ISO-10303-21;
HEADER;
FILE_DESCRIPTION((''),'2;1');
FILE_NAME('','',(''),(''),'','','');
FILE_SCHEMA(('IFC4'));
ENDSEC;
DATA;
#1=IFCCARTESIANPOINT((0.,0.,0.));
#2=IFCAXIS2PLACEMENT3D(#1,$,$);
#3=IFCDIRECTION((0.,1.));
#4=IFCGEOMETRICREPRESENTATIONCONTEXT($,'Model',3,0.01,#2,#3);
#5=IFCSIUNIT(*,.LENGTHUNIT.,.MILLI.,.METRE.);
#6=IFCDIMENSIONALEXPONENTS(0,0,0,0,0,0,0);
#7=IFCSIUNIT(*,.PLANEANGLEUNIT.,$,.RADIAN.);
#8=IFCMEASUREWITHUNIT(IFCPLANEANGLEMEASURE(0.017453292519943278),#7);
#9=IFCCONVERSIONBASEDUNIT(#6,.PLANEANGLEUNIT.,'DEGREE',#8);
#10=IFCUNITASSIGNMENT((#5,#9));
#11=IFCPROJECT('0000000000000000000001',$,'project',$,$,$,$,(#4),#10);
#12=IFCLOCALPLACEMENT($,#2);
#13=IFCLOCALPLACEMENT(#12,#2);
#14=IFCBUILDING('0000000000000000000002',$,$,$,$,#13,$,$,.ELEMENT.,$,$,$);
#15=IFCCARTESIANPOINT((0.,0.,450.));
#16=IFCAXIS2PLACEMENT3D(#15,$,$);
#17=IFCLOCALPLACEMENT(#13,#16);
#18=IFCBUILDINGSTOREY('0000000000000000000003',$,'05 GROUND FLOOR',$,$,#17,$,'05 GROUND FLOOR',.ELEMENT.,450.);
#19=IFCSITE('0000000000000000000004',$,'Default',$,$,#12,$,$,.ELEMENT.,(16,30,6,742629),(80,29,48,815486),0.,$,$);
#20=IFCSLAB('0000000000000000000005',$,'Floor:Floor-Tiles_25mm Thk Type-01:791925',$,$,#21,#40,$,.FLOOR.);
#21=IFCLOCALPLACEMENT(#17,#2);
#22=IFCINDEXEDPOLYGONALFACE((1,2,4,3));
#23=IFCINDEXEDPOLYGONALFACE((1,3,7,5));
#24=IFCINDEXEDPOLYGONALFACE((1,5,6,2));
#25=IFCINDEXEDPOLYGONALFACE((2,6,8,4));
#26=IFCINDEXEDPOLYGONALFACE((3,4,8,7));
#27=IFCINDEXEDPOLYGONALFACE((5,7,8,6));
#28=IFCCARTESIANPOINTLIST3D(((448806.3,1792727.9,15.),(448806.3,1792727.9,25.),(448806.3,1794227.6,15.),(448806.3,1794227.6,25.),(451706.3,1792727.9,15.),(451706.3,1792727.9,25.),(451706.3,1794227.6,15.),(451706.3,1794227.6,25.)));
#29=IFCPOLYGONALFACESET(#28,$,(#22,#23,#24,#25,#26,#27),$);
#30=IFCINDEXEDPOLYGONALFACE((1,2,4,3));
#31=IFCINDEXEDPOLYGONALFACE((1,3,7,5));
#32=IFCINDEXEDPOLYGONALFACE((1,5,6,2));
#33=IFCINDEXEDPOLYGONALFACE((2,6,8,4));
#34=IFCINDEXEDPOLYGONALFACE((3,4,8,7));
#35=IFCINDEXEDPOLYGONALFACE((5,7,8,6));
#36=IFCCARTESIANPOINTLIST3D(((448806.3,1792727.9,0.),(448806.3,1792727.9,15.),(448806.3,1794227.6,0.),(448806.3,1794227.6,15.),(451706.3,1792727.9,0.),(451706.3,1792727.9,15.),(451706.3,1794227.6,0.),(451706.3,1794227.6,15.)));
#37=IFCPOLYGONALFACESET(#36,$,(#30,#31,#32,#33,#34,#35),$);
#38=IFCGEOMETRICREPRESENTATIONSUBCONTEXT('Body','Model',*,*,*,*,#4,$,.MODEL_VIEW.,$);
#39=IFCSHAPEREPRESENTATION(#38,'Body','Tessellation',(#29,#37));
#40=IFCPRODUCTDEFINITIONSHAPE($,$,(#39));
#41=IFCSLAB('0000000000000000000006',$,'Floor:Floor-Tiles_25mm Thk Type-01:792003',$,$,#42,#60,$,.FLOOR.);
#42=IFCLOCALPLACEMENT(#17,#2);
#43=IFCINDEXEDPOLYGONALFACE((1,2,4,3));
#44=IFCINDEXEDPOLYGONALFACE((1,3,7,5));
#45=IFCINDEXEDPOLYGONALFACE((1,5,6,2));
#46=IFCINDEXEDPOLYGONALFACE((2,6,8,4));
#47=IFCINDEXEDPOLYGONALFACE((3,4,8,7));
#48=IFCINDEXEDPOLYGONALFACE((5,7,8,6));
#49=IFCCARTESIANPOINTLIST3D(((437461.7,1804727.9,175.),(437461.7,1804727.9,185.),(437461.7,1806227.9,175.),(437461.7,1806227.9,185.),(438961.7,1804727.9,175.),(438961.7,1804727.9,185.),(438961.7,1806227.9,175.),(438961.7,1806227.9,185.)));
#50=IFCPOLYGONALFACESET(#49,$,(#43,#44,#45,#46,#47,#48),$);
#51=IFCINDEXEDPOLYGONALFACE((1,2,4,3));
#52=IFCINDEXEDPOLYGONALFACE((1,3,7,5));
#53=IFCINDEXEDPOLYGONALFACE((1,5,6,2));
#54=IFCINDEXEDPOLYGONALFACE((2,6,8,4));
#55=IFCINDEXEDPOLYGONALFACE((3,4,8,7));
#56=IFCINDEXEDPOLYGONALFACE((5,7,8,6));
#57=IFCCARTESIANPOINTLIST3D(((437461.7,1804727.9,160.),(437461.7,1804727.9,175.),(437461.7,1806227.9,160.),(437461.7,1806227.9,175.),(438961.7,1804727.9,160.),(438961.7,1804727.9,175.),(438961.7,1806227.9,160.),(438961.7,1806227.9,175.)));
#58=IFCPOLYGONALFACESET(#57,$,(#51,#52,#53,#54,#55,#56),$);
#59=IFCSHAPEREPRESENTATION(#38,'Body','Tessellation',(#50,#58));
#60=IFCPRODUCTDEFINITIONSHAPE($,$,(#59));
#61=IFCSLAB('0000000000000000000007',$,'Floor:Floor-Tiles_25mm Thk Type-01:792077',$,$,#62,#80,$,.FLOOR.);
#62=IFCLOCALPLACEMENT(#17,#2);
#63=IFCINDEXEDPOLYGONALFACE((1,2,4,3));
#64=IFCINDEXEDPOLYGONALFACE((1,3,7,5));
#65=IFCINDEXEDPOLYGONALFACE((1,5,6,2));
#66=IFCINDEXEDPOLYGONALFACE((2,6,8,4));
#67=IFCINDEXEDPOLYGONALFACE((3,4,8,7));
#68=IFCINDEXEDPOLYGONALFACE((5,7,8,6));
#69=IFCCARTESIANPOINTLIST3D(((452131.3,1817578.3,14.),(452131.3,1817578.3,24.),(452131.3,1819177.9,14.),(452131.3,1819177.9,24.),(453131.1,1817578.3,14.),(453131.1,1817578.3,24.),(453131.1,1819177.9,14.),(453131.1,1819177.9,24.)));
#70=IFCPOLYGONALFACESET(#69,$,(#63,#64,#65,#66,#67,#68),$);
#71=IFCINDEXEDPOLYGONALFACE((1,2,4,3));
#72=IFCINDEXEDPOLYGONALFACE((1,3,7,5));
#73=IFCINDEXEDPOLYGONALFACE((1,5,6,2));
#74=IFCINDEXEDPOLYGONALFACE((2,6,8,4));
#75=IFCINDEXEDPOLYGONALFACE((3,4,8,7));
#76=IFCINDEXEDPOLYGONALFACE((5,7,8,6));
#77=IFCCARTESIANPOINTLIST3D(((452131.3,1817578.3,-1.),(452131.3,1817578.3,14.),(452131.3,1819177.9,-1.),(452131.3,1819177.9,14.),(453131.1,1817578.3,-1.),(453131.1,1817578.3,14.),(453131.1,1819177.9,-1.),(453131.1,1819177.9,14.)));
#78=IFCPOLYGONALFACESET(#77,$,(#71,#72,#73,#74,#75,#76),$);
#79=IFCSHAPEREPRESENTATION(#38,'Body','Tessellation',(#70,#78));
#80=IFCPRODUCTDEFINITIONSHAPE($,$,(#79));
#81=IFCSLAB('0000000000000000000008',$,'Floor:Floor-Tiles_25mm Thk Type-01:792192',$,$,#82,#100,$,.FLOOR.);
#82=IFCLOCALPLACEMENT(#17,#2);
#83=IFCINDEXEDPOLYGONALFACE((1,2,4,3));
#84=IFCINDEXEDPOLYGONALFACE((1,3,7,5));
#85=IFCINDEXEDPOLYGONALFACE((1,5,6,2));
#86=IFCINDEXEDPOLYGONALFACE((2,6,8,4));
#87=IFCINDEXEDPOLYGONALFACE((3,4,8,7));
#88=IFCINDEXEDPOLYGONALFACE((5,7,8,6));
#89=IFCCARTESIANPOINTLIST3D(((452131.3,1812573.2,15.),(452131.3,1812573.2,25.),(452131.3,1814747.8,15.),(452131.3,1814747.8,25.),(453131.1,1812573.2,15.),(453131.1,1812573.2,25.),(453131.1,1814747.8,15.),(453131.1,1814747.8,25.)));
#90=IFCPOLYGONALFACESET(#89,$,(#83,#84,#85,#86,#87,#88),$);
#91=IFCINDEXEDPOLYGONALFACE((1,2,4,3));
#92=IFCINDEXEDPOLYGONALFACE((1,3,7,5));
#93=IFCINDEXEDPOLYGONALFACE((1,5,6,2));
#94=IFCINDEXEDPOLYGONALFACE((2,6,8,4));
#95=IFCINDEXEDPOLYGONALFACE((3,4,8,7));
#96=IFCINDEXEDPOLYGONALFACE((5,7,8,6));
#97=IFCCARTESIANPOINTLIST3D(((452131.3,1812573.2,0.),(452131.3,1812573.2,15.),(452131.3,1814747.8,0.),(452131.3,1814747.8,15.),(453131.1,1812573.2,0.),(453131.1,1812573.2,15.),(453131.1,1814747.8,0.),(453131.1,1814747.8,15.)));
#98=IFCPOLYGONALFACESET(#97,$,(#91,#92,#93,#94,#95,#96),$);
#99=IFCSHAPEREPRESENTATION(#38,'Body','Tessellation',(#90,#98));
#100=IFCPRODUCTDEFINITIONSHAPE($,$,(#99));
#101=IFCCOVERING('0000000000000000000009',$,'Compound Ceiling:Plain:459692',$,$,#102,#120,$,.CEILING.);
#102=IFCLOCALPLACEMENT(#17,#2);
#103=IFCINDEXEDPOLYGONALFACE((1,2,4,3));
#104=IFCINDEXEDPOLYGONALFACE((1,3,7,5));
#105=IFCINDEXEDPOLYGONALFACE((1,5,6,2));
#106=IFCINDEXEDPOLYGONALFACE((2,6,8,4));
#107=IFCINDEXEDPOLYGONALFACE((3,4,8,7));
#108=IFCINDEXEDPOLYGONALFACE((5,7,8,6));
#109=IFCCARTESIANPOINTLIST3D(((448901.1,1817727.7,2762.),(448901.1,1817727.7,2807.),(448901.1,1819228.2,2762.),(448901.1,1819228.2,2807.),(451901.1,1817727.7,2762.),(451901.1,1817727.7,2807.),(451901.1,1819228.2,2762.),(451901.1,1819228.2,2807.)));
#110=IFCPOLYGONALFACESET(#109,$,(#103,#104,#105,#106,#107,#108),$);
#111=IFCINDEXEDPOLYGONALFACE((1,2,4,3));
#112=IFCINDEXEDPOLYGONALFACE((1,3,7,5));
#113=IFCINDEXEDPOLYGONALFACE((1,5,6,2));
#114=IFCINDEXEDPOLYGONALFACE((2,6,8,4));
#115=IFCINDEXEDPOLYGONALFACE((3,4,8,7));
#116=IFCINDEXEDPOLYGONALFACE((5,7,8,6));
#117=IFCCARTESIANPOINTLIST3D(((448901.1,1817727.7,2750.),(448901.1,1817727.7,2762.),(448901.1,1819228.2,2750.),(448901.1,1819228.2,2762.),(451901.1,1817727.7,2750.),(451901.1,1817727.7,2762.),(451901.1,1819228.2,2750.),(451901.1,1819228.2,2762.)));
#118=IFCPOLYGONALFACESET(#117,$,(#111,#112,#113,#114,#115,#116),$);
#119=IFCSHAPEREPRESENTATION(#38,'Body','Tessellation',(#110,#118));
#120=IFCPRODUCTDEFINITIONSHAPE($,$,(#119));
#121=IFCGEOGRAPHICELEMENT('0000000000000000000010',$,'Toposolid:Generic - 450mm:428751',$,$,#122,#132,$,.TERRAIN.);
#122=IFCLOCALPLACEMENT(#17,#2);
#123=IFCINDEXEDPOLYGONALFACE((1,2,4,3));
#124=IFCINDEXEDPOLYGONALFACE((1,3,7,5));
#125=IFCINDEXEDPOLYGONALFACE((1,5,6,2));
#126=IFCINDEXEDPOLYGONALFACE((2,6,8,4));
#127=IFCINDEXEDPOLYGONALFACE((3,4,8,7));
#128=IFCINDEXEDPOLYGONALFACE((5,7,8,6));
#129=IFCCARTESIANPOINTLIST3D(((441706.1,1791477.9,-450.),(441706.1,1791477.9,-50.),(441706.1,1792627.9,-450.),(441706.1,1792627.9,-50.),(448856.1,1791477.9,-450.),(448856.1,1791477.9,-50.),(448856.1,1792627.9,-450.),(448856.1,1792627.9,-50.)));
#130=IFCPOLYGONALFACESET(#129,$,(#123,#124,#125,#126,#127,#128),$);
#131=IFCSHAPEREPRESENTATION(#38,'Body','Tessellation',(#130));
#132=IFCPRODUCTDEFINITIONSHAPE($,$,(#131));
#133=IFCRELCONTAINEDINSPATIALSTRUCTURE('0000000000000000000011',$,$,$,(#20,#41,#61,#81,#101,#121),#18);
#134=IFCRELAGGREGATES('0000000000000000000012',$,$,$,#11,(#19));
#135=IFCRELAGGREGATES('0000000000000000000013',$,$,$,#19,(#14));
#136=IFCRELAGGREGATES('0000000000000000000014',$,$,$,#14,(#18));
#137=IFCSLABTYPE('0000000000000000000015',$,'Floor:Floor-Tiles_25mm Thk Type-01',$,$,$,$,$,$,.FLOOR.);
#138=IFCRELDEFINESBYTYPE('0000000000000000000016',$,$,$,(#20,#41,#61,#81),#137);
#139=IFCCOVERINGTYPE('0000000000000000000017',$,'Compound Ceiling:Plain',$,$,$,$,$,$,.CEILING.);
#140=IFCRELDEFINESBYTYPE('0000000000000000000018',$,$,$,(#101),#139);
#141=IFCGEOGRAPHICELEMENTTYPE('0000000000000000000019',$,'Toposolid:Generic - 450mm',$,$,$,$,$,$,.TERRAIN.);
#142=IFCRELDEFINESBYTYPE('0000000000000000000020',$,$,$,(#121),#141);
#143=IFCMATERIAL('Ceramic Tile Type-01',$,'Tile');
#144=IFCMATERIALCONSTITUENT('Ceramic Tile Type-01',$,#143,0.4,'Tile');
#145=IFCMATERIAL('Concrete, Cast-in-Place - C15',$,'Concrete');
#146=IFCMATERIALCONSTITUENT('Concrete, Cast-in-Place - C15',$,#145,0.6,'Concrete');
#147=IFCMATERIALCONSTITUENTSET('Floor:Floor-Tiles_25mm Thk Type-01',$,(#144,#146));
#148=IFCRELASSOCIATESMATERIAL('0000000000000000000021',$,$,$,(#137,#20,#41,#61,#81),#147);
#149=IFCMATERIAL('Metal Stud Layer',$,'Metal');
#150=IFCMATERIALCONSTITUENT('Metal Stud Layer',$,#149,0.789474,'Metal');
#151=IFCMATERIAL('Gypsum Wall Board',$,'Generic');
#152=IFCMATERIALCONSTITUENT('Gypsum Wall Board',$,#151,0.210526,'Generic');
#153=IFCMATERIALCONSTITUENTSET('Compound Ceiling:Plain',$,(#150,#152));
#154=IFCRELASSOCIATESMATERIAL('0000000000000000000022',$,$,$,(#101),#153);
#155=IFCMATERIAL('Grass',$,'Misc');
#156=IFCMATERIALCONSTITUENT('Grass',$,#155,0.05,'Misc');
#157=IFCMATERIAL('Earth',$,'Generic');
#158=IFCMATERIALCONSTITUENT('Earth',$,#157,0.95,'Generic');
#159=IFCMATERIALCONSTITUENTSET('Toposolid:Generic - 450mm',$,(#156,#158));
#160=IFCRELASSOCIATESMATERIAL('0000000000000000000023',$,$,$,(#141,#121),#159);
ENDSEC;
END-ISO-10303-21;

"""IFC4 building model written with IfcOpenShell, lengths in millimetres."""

from ifc_helpers import new_model, entity, si_unit, converted_unit, direction, frame, origin, place, context, subcontext, project, spatial, indexed_curve, outline, extrude, material, constituent, constituent_set, type_object, element, save


model = new_model("IFC4")

# Units and contexts
model_context = context("Model", 3, precision=0.01, world=origin(), true_north=direction((0.0, 1.0)))
body_context = subcontext(model_context, "Body", "Model", "MODEL_VIEW")
ifc_project = project(units=[si_unit("LENGTHUNIT", "METRE", prefix="MILLI"), converted_unit("PLANEANGLEUNIT", "DEGREE", entity("IfcPlaneAngleMeasure", 0.017453292519943278), si_unit("PLANEANGLEUNIT", "RADIAN"), dimensions=[0, 0, 0, 0, 0, 0, 0])], contexts=[model_context])

# Site, building, storey
site_placement = place(None, origin())
site = spatial("IfcSite", under=ifc_project, at=site_placement, Name="Default", CompositionType="ELEMENT", RefLatitude=(16, 30, 6, 742629), RefLongitude=(80, 29, 48, 815486), RefElevation=0.0)
building_placement = place(site_placement, origin())
building = spatial("IfcBuilding", under=site, at=building_placement, CompositionType="ELEMENT")
storey_placement = place(building_placement, frame((0.0, 0.0, 450.0)))
storey = spatial("IfcBuildingStorey", under=building, at=storey_placement, Name="05 GROUND FLOOR", LongName="05 GROUND FLOOR", CompositionType="ELEMENT", Elevation=450.0)

# Slabs
ifc_material_1 = material(Name="Concrete, Cast-in-Place - C15", Category="Concrete")
ifc_material_2 = material(Name="Ceramic Tile Type-01", Category="Tile")
ifc_constituent_1 = constituent(ifc_material_2, Name="Ceramic Tile Type-01", Category="Tile", fraction=0.4)
ifc_constituent_2 = constituent(ifc_material_1, Name="Concrete, Cast-in-Place - C15", Category="Concrete", fraction=0.6)
ifc_constituent_set_1 = constituent_set(constituents=[ifc_constituent_1, ifc_constituent_2], Name="Floor:Floor-Tiles_25mm Thk Type-01")
slab_type_1 = type_object("IfcSlabType", Name="Floor:Floor-Tiles_25mm Thk Type-01", PredefinedType="FLOOR", material=ifc_constituent_set_1)
slab_1_placement = place(storey_placement, origin())
element("IfcSlab", 1, at=slab_1_placement, inside=storey, type_object=slab_type_1, material=ifc_constituent_set_1, Name="Floor:Floor-Tiles_25mm Thk Type-01:791925", PredefinedType="FLOOR", context=body_context, shape_type="SweptSolid", body=[
    extrude(outline(indexed_curve([(-1450.0, -749.9), (1450.0, -749.9), (1450.0, 749.9), (-1450.0, 749.9), (-1450.0, -749.9)], self_intersect=False)), frame((450256.3, 1793477.8, 15.0), z_axis=(0.0, 0.0, 1.0), x_axis=(-1.0, 0.0, 0.0)), (0.0, 0.0, 1.0), 10.0),
    extrude(outline(indexed_curve([(-1450.0, -749.9), (1450.0, -749.9), (1450.0, 749.9), (-1450.0, 749.9), (-1450.0, -749.9)], self_intersect=False)), frame((450256.3, 1793477.8, 0.0), z_axis=(0.0, 0.0, 1.0), x_axis=(-1.0, 0.0, 0.0)), (0.0, 0.0, 1.0), 15.0),
])
slab_2_placement = place(storey_placement, origin())
element("IfcSlab", 2, at=slab_2_placement, inside=storey, type_object=slab_type_1, material=ifc_constituent_set_1, Name="Floor:Floor-Tiles_25mm Thk Type-01:792003", PredefinedType="FLOOR", context=body_context, shape_type="SweptSolid", body=[
    extrude(outline(indexed_curve([(-750.0, -750.0), (750.0, -750.0), (750.0, 750.0), (-750.0, 750.0), (-750.0, -750.0)], self_intersect=False)), frame((438211.7, 1805477.9, 175.0), z_axis=(0.0, 0.0, 1.0), x_axis=(0.0, 1.0, 0.0)), (0.0, 0.0, 1.0), 10.0),
    extrude(outline(indexed_curve([(-750.0, -750.0), (750.0, -750.0), (750.0, 750.0), (-750.0, 750.0), (-750.0, -750.0)], self_intersect=False)), frame((438211.7, 1805477.9, 160.0), z_axis=(0.0, 0.0, 1.0), x_axis=(0.0, 1.0, 0.0)), (0.0, 0.0, 1.0), 15.0),
])
slab_3_placement = place(storey_placement, origin())
element("IfcSlab", 3, at=slab_3_placement, inside=storey, type_object=slab_type_1, material=ifc_constituent_set_1, Name="Floor:Floor-Tiles_25mm Thk Type-01:792077", PredefinedType="FLOOR", context=body_context, shape_type="SweptSolid", body=[
    extrude(outline(indexed_curve([(-799.8, -499.9), (799.8, -499.9), (799.8, 499.9), (-799.8, 499.9), (-799.8, -499.9)], self_intersect=False)), frame((452631.2, 1818378.1, 14.0), z_axis=(0.0, 0.0, 1.0), x_axis=(0.0, -1.0, 0.0)), (0.0, 0.0, 1.0), 10.0),
    extrude(outline(indexed_curve([(-799.8, -499.9), (799.8, -499.9), (799.8, 499.9), (-799.8, 499.9), (-799.8, -499.9)], self_intersect=False)), frame((452631.2, 1818378.1, -1.0), z_axis=(0.0, 0.0, 1.0), x_axis=(0.0, -1.0, 0.0)), (0.0, 0.0, 1.0), 15.0),
])
slab_4_placement = place(storey_placement, origin())
element("IfcSlab", 4, at=slab_4_placement, inside=storey, type_object=slab_type_1, material=ifc_constituent_set_1, Name="Floor:Floor-Tiles_25mm Thk Type-01:792192", PredefinedType="FLOOR", context=body_context, shape_type="SweptSolid", body=[
    extrude(outline(indexed_curve([(-499.9, -1087.3), (499.9, -1087.3), (499.9, 1087.3), (-499.9, 1087.3), (-499.9, -1087.3)], self_intersect=False)), frame((452631.2, 1813660.5, 15.0), z_axis=(0.0, 0.0, 1.0), x_axis=(-1.0, 0.0, 0.0)), (0.0, 0.0, 1.0), 10.0),
    extrude(outline(indexed_curve([(-499.9, -1087.3), (499.9, -1087.3), (499.9, 1087.3), (-499.9, 1087.3), (-499.9, -1087.3)], self_intersect=False)), frame((452631.2, 1813660.5, 0.0), z_axis=(0.0, 0.0, 1.0), x_axis=(-1.0, 0.0, 0.0)), (0.0, 0.0, 1.0), 15.0),
])

# Covering
ifc_material_3 = material(Name="Metal Stud Layer", Category="Metal")
ifc_constituent_3 = constituent(ifc_material_3, Name="Metal Stud Layer", Category="Metal", fraction=0.789474)
ifc_material_4 = material(Name="Gypsum Wall Board", Category="Generic")
ifc_constituent_4 = constituent(ifc_material_4, Name="Gypsum Wall Board", Category="Generic", fraction=0.210526)
ifc_constituent_set_2 = constituent_set(constituents=[ifc_constituent_3, ifc_constituent_4], Name="Compound Ceiling:Plain")
covering_type = type_object("IfcCoveringType", Name="Compound Ceiling:Plain", PredefinedType="CEILING")
covering_1_placement = place(storey_placement, origin())
element("IfcCovering", 5, at=covering_1_placement, inside=storey, type_object=covering_type, material=ifc_constituent_set_2, Name="Compound Ceiling:Plain:459692", PredefinedType="CEILING", context=body_context, shape_type="SweptSolid", body=[
    extrude(outline(indexed_curve([(-1500.0, -750.2), (1500.0, -750.2), (1500.0, 750.2), (-1500.0, 750.2), (-1500.0, -750.2)], self_intersect=False)), frame((450401.1, 1818477.9, 2762.0), z_axis=(0.0, 0.0, 1.0), x_axis=(-1.0, 0.0, 0.0)), (0.0, 0.0, 1.0), 45.0),
    extrude(outline(indexed_curve([(-750.2, -1500.0), (750.2, -1500.0), (750.2, 1500.0), (-750.2, 1500.0), (-750.2, -1500.0)], self_intersect=False)), frame((450401.1, 1818477.9, 2750.0), z_axis=(0.0, 0.0, 1.0), x_axis=(0.0, 1.0, 0.0)), (0.0, 0.0, 1.0), 12.0),
])

# Geographic element
ifc_material_5 = material(Name="Grass", Category="Misc")
ifc_constituent_5 = constituent(ifc_material_5, Name="Grass", Category="Misc", fraction=0.05)
ifc_material_6 = material(Name="Earth", Category="Generic")
ifc_constituent_6 = constituent(ifc_material_6, Name="Earth", Category="Generic", fraction=0.95)
ifc_constituent_set_3 = constituent_set(constituents=[ifc_constituent_5, ifc_constituent_6], Name="Toposolid:Generic - 450mm")
geographic_element_type = type_object("IfcGeographicElementType", Name="Toposolid:Generic - 450mm", PredefinedType="TERRAIN", material=ifc_constituent_set_3)
geographic_element_1_placement = place(storey_placement, origin())
element("IfcGeographicElement", 6, at=geographic_element_1_placement, inside=storey, type_object=geographic_element_type, material=ifc_constituent_set_3, Name="Toposolid:Generic - 450mm:428751", PredefinedType="TERRAIN", context=body_context, shape_type="SweptSolid", body=[
    extrude(outline(indexed_curve([(-3575.0, -575.0), (3575.0, -575.0), (3575.0, 575.0), (-3575.0, 575.0), (-3575.0, -575.0)], self_intersect=False)), frame((445281.1, 1792052.9, -450.0), z_axis=(0.0, 0.0, 1.0), x_axis=(-1.0, 0.0, 0.0)), (0.0, 0.0, 1.0), 400.0),
])

save(model, "model.ifc")
